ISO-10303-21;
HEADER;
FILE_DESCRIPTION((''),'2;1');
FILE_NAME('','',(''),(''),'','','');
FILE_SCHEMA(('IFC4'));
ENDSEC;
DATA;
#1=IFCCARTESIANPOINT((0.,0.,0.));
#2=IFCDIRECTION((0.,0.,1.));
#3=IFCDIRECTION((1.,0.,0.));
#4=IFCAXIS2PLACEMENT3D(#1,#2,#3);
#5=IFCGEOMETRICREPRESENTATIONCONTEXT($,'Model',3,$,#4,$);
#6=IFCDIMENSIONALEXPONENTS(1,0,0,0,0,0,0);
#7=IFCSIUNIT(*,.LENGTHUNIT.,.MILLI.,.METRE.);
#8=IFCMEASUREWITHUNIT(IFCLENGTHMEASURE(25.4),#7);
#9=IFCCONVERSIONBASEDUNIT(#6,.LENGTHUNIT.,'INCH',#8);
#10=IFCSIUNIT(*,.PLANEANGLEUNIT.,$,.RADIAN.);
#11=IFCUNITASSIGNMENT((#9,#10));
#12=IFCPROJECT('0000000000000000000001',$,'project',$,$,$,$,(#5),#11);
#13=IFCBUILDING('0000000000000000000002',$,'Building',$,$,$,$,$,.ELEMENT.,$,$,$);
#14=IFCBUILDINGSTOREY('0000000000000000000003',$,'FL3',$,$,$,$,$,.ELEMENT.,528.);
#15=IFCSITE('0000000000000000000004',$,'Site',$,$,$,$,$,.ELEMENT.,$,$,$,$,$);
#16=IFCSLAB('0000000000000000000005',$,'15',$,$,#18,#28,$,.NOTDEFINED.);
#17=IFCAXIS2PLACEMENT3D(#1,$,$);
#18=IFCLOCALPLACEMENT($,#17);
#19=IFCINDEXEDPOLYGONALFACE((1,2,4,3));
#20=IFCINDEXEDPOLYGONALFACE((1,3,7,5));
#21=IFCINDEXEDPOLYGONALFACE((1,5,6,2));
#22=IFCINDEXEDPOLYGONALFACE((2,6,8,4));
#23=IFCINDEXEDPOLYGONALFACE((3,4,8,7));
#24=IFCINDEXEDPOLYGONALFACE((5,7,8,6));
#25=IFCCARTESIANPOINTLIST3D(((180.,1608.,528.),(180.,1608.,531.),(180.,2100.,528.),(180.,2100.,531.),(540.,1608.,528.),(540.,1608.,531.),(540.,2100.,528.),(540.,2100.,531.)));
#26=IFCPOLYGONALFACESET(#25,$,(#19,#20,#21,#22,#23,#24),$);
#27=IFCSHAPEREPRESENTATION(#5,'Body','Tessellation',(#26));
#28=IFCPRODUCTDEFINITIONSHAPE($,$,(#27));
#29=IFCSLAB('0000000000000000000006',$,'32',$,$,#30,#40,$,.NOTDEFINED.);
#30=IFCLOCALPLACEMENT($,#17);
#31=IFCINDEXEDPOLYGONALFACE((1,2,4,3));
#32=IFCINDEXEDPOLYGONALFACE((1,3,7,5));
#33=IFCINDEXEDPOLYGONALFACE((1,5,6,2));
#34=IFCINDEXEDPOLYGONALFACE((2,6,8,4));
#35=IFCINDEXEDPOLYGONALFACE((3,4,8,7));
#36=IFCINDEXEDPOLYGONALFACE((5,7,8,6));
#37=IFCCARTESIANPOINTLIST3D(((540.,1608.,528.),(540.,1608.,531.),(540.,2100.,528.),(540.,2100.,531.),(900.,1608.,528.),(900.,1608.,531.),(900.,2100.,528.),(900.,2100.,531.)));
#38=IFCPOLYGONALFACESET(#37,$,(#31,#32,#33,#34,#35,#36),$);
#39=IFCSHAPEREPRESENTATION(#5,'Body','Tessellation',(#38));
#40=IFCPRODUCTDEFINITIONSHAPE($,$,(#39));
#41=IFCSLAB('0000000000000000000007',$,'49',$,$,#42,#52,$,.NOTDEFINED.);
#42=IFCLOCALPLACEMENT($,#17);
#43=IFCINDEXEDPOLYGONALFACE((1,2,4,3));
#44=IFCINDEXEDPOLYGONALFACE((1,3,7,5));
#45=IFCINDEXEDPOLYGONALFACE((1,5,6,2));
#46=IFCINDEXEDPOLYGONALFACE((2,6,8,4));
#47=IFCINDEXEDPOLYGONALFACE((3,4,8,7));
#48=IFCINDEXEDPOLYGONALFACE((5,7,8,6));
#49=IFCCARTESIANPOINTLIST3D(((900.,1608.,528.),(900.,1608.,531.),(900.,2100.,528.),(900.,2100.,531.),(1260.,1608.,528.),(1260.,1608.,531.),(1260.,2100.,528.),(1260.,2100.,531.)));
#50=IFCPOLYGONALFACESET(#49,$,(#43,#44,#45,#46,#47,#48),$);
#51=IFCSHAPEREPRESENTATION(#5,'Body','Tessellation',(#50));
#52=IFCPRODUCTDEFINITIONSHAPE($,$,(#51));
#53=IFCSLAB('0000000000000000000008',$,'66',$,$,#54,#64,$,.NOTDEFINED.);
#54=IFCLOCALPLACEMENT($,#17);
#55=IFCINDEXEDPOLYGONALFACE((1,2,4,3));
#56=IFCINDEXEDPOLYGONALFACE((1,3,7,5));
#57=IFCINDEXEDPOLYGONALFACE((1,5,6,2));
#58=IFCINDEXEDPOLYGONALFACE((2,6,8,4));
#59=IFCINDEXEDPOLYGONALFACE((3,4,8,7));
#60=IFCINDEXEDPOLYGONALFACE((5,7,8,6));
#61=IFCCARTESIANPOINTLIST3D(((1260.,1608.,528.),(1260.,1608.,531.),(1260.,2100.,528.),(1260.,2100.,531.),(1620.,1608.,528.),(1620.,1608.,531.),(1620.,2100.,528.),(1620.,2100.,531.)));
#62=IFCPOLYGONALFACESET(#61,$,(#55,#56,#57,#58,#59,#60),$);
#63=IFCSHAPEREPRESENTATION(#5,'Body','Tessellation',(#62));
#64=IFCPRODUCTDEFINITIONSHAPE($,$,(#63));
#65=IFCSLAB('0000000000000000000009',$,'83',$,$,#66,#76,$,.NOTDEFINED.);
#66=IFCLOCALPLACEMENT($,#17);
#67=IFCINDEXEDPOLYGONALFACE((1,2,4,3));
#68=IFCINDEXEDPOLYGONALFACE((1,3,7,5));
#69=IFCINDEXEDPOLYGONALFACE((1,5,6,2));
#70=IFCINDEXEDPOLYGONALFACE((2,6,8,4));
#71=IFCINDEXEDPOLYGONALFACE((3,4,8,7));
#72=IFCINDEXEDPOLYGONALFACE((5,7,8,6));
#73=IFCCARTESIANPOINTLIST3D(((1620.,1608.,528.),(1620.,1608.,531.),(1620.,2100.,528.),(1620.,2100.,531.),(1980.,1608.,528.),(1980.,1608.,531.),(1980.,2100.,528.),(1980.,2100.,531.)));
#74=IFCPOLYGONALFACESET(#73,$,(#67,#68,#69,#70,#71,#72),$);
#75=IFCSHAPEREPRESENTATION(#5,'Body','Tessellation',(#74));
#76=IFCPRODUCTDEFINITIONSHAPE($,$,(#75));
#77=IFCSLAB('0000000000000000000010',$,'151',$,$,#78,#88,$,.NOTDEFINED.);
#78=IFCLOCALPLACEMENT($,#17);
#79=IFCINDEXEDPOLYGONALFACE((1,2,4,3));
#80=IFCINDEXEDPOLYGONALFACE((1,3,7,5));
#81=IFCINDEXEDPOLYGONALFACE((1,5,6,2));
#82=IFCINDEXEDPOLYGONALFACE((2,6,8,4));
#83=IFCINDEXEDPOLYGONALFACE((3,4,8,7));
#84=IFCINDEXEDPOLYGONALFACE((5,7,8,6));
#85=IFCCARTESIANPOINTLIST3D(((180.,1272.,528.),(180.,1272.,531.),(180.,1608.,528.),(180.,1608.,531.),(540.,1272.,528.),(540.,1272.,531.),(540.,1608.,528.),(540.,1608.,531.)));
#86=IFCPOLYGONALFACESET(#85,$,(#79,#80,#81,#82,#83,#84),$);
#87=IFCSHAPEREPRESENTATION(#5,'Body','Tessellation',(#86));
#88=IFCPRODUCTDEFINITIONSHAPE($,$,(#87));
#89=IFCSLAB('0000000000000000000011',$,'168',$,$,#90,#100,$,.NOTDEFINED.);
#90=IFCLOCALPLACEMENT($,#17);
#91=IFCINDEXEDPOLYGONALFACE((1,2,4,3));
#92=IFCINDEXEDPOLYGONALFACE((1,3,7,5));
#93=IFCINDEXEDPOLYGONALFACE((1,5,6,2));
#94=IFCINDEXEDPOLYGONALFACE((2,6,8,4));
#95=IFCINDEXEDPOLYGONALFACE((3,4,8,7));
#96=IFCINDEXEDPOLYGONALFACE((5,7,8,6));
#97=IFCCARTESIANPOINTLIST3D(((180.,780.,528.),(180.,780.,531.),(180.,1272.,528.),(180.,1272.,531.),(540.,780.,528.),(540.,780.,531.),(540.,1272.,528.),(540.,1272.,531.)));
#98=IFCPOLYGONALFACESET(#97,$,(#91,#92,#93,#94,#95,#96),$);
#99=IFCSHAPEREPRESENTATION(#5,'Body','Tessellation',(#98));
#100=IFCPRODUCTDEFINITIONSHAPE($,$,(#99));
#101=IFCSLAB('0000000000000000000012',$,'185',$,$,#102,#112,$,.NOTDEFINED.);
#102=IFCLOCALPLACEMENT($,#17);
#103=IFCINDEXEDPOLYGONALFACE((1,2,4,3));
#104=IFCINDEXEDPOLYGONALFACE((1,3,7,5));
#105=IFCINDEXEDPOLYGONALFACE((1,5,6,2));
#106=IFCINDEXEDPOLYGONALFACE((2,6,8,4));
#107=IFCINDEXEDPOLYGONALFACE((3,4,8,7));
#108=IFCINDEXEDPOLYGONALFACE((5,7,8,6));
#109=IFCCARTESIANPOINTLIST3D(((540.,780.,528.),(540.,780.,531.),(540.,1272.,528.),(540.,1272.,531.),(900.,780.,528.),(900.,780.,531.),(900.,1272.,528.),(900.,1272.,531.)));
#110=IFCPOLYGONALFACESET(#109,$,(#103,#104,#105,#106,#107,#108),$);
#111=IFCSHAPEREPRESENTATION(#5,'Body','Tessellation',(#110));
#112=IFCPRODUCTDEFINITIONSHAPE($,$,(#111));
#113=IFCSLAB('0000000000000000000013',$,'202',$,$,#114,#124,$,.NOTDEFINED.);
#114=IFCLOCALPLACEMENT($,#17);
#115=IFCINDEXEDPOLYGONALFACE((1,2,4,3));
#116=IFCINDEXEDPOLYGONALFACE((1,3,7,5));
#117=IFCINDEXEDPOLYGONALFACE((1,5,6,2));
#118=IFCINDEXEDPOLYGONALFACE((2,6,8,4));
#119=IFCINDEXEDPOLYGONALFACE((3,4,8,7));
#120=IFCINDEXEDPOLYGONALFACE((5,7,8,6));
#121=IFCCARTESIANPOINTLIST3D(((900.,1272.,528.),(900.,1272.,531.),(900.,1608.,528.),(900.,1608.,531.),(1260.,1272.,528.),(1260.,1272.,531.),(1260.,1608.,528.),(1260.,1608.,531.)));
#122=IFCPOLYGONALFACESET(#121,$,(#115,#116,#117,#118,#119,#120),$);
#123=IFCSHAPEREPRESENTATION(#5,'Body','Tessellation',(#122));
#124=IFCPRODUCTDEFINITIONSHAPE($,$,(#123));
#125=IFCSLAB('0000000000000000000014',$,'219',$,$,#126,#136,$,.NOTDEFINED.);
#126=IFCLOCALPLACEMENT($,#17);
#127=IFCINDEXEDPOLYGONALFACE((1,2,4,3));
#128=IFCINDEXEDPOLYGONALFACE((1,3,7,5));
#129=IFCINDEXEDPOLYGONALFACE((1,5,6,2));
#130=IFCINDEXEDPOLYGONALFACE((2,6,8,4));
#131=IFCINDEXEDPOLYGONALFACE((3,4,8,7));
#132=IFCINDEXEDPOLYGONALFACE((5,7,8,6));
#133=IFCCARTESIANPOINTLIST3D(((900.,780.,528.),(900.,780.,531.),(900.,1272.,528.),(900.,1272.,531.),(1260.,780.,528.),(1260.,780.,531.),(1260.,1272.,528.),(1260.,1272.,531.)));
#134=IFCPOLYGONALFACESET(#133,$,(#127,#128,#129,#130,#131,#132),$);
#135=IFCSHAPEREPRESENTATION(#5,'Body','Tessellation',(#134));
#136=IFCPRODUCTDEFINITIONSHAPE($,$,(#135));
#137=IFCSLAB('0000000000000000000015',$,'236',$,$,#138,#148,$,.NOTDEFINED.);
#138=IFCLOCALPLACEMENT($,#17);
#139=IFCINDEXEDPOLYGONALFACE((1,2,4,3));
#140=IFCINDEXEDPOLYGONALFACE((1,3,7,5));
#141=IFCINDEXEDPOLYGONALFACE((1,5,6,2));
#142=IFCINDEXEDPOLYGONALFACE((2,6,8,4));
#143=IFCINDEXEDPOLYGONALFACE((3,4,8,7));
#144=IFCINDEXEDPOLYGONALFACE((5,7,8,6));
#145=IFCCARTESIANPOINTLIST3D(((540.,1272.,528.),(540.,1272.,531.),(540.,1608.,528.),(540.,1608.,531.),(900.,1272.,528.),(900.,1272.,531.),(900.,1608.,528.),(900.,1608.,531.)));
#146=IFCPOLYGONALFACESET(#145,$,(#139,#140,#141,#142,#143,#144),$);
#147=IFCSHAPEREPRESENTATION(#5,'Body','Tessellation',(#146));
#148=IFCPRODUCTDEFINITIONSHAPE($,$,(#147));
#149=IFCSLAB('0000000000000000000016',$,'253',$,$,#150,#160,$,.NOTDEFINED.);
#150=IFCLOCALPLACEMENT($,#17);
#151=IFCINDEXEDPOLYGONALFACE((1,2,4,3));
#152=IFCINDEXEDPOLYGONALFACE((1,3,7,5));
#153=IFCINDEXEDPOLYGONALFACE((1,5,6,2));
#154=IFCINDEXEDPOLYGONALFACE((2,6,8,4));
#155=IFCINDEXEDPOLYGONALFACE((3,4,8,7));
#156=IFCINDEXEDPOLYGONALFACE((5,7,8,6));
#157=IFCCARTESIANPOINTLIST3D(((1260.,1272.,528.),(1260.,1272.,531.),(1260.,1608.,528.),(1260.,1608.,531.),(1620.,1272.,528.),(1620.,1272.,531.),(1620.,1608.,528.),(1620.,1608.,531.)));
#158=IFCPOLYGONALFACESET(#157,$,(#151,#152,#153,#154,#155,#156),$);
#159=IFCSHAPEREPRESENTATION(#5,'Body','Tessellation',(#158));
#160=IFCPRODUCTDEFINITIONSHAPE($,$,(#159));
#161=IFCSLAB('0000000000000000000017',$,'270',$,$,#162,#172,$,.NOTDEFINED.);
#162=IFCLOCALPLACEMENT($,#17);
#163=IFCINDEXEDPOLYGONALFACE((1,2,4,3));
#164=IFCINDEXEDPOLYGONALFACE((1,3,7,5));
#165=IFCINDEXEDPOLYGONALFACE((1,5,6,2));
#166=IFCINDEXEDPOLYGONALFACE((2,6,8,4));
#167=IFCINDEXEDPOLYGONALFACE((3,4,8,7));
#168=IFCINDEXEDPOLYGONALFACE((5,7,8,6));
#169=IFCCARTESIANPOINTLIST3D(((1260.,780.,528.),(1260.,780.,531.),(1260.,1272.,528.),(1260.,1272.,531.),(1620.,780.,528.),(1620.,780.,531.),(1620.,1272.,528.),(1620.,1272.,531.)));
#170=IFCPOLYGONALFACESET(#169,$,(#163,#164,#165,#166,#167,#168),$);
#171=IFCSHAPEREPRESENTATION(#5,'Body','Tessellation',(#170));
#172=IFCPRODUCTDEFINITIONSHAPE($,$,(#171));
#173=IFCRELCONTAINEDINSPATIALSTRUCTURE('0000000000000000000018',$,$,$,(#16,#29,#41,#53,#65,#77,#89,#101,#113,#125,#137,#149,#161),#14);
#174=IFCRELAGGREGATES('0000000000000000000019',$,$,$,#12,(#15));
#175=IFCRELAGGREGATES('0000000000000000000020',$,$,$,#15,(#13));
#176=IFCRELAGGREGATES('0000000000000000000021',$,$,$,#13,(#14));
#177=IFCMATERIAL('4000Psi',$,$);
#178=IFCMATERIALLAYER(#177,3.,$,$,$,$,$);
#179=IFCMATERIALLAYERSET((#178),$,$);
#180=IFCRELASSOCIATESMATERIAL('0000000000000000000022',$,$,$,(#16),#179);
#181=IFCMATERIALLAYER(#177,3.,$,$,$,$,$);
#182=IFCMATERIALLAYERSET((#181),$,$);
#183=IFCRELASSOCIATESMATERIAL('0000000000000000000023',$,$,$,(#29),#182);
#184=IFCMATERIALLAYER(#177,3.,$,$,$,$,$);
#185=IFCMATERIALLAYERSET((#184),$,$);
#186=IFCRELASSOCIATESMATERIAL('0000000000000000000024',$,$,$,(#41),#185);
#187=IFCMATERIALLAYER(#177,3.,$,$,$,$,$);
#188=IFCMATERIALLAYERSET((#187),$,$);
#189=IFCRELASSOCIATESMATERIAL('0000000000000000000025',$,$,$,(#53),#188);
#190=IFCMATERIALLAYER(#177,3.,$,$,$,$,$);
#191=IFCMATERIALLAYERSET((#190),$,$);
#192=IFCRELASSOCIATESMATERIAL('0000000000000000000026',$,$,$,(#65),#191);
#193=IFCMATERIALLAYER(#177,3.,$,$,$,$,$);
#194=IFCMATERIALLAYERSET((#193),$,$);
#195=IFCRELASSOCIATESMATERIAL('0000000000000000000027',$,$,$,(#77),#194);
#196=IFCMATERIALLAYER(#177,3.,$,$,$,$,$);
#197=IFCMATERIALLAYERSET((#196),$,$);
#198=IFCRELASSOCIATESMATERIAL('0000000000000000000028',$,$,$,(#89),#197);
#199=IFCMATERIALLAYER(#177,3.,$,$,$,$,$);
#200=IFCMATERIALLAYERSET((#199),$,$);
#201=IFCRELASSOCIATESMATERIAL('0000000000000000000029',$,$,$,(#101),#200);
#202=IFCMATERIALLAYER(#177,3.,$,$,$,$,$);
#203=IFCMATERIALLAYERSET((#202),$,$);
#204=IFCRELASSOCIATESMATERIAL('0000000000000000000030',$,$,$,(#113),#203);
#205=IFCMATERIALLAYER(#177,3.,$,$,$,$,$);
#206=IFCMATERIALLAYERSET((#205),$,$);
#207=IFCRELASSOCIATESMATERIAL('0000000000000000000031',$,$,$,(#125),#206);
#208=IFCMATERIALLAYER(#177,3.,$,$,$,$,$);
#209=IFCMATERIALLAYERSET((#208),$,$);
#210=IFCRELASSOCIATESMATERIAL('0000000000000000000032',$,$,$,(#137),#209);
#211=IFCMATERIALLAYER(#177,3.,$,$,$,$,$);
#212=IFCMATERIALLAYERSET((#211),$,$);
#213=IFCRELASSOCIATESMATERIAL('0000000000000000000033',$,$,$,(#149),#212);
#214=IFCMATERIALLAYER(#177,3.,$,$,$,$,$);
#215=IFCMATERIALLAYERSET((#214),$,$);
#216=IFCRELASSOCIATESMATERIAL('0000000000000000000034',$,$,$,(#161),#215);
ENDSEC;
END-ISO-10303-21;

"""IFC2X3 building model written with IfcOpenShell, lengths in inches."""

from ifc_helpers import new_model, entity, si_unit, converted_unit, frame, origin_with_axes, place, context, project, spatial, polyline, outline, extrude, material, layer, layer_set, layer_usage, element, save


model = new_model("IFC2X3")

# Units and contexts
model_context = context("Model", 3, world=origin_with_axes())
ifc_project = project(units=[converted_unit("LENGTHUNIT", "INCH", entity("IfcLengthMeasure", 25.4), si_unit("LENGTHUNIT", "METRE", prefix="MILLI"), dimensions=[1, 0, 0, 0, 0, 0, 0]), si_unit("PLANEANGLEUNIT", "RADIAN")], contexts=[model_context])

# Site, building, storey
site = spatial("IfcSite", under=ifc_project, Name="Site", CompositionType="ELEMENT")
building = spatial("IfcBuilding", under=site, Name="Building", CompositionType="ELEMENT")
storey = spatial("IfcBuildingStorey", under=building, Name="FL3", CompositionType="ELEMENT", Elevation=528.0)

# Slabs
ifc_material_1 = material(Name="4000Psi")
ifc_layer_1 = layer(ifc_material_1, 3.0)
ifc_layer_set_1 = layer_set([ifc_layer_1])
ifc_layer_usage_1 = layer_usage(ifc_layer_set_1, "AXIS2", "POSITIVE", -3.0)
slab_1_placement = place(None, frame((180.0, 1608.0, 528.0), z_axis=(0.0, 0.0, 1.0), x_axis=(1.0, 0.0, 0.0)))
element("IfcSlab", 1, at=slab_1_placement, inside=storey, material=ifc_layer_usage_1, Name="15", PredefinedType="NOTDEFINED", context=model_context, shape_type="SweptSolid", body=[
    extrude(outline(polyline([(0.0, 0.0), (360.0, 0.0), (360.0, 492.0), (0.0, 492.0), (0.0, 0.0)])), origin_with_axes(), (0.0, 0.0, 1.0), 3.0),
])
ifc_layer_2 = layer(ifc_material_1, 3.0)
ifc_layer_set_2 = layer_set([ifc_layer_2])
ifc_layer_usage_2 = layer_usage(ifc_layer_set_2, "AXIS2", "POSITIVE", -3.0)
slab_2_placement = place(None, frame((540.0, 1608.0, 528.0), z_axis=(0.0, 0.0, 1.0), x_axis=(1.0, 0.0, 0.0)))
element("IfcSlab", 2, at=slab_2_placement, inside=storey, material=ifc_layer_usage_2, Name="32", PredefinedType="NOTDEFINED", context=model_context, shape_type="SweptSolid", body=[
    extrude(outline(polyline([(0.0, 0.0), (360.0, 0.0), (360.0, 492.0), (0.0, 492.0), (0.0, 0.0)])), origin_with_axes(), (0.0, 0.0, 1.0), 3.0),
])
ifc_layer_3 = layer(ifc_material_1, 3.0)
ifc_layer_set_3 = layer_set([ifc_layer_3])
ifc_layer_usage_3 = layer_usage(ifc_layer_set_3, "AXIS2", "POSITIVE", -3.0)
slab_3_placement = place(None, frame((900.0, 1608.0, 528.0), z_axis=(0.0, 0.0, 1.0), x_axis=(1.0, 0.0, 0.0)))
element("IfcSlab", 3, at=slab_3_placement, inside=storey, material=ifc_layer_usage_3, Name="49", PredefinedType="NOTDEFINED", context=model_context, shape_type="SweptSolid", body=[
    extrude(outline(polyline([(0.0, 0.0), (360.0, 0.0), (360.0, 492.0), (0.0, 492.0), (0.0, 0.0)])), origin_with_axes(), (0.0, 0.0, 1.0), 3.0),
])
ifc_layer_4 = layer(ifc_material_1, 3.0)
ifc_layer_set_4 = layer_set([ifc_layer_4])
ifc_layer_usage_4 = layer_usage(ifc_layer_set_4, "AXIS2", "POSITIVE", -3.0)
slab_4_placement = place(None, frame((1260.0, 1608.0, 528.0), z_axis=(0.0, 0.0, 1.0), x_axis=(1.0, 0.0, 0.0)))
element("IfcSlab", 4, at=slab_4_placement, inside=storey, material=ifc_layer_usage_4, Name="66", PredefinedType="NOTDEFINED", context=model_context, shape_type="SweptSolid", body=[
    extrude(outline(polyline([(0.0, 0.0), (360.0, 0.0), (360.0, 492.0), (0.0, 492.0), (0.0, 0.0)])), origin_with_axes(), (0.0, 0.0, 1.0), 3.0),
])
ifc_layer_5 = layer(ifc_material_1, 3.0)
ifc_layer_set_5 = layer_set([ifc_layer_5])
ifc_layer_usage_5 = layer_usage(ifc_layer_set_5, "AXIS2", "POSITIVE", -3.0)
slab_5_placement = place(None, frame((1620.0, 1608.0, 528.0), z_axis=(0.0, 0.0, 1.0), x_axis=(1.0, 0.0, 0.0)))
element("IfcSlab", 5, at=slab_5_placement, inside=storey, material=ifc_layer_usage_5, Name="83", PredefinedType="NOTDEFINED", context=model_context, shape_type="SweptSolid", body=[
    extrude(outline(polyline([(0.0, 0.0), (360.0, 0.0), (360.0, 492.0), (0.0, 492.0), (0.0, 0.0)])), origin_with_axes(), (0.0, 0.0, 1.0), 3.0),
])
ifc_layer_6 = layer(ifc_material_1, 3.0)
ifc_layer_set_6 = layer_set([ifc_layer_6])
ifc_layer_usage_6 = layer_usage(ifc_layer_set_6, "AXIS2", "POSITIVE", -3.0)
slab_6_placement = place(None, frame((180.0, 1272.0, 528.0), z_axis=(0.0, 0.0, 1.0), x_axis=(1.0, 0.0, 0.0)))
element("IfcSlab", 6, at=slab_6_placement, inside=storey, material=ifc_layer_usage_6, Name="151", PredefinedType="NOTDEFINED", context=model_context, shape_type="SweptSolid", body=[
    extrude(outline(polyline([(0.0, 0.0), (360.0, 0.0), (360.0, 336.0), (0.0, 336.0), (0.0, 0.0)])), origin_with_axes(), (0.0, 0.0, 1.0), 3.0),
])
ifc_layer_7 = layer(ifc_material_1, 3.0)
ifc_layer_set_7 = layer_set([ifc_layer_7])
ifc_layer_usage_7 = layer_usage(ifc_layer_set_7, "AXIS2", "POSITIVE", -3.0)
slab_7_placement = place(None, frame((180.0, 780.0, 528.0), z_axis=(0.0, 0.0, 1.0), x_axis=(1.0, 0.0, 0.0)))
element("IfcSlab", 7, at=slab_7_placement, inside=storey, material=ifc_layer_usage_7, Name="168", PredefinedType="NOTDEFINED", context=model_context, shape_type="SweptSolid", body=[
    extrude(outline(polyline([(0.0, 0.0), (360.0, 0.0), (360.0, 492.0), (0.0, 492.0), (0.0, 0.0)])), origin_with_axes(), (0.0, 0.0, 1.0), 3.0),
])
ifc_layer_8 = layer(ifc_material_1, 3.0)
ifc_layer_set_8 = layer_set([ifc_layer_8])
ifc_layer_usage_8 = layer_usage(ifc_layer_set_8, "AXIS2", "POSITIVE", -3.0)
slab_8_placement = place(None, frame((540.0, 780.0, 528.0), z_axis=(0.0, 0.0, 1.0), x_axis=(1.0, 0.0, 0.0)))
element("IfcSlab", 8, at=slab_8_placement, inside=storey, material=ifc_layer_usage_8, Name="185", PredefinedType="NOTDEFINED", context=model_context, shape_type="SweptSolid", body=[
    extrude(outline(polyline([(0.0, 0.0), (360.0, 0.0), (360.0, 492.0), (0.0, 492.0), (0.0, 0.0)])), origin_with_axes(), (0.0, 0.0, 1.0), 3.0),
])
ifc_layer_9 = layer(ifc_material_1, 3.0)
ifc_layer_set_9 = layer_set([ifc_layer_9])
ifc_layer_usage_9 = layer_usage(ifc_layer_set_9, "AXIS2", "POSITIVE", -3.0)
slab_9_placement = place(None, frame((900.0, 1272.0, 528.0), z_axis=(0.0, 0.0, 1.0), x_axis=(1.0, 0.0, 0.0)))
element("IfcSlab", 9, at=slab_9_placement, inside=storey, material=ifc_layer_usage_9, Name="202", PredefinedType="NOTDEFINED", context=model_context, shape_type="SweptSolid", body=[
    extrude(outline(polyline([(0.0, 0.0), (360.0, 0.0), (360.0, 336.0), (0.0, 336.0), (0.0, 0.0)])), origin_with_axes(), (0.0, 0.0, 1.0), 3.0),
])
ifc_layer_10 = layer(ifc_material_1, 3.0)
ifc_layer_set_10 = layer_set([ifc_layer_10])
ifc_layer_usage_10 = layer_usage(ifc_layer_set_10, "AXIS2", "POSITIVE", -3.0)
slab_10_placement = place(None, frame((900.0, 780.0, 528.0), z_axis=(0.0, 0.0, 1.0), x_axis=(1.0, 0.0, 0.0)))
element("IfcSlab", 10, at=slab_10_placement, inside=storey, material=ifc_layer_usage_10, Name="219", PredefinedType="NOTDEFINED", context=model_context, shape_type="SweptSolid", body=[
    extrude(outline(polyline([(0.0, 0.0), (360.0, 0.0), (360.0, 492.0), (0.0, 492.0), (0.0, 0.0)])), origin_with_axes(), (0.0, 0.0, 1.0), 3.0),
])
ifc_layer_11 = layer(ifc_material_1, 3.0)
ifc_layer_set_11 = layer_set([ifc_layer_11])
ifc_layer_usage_11 = layer_usage(ifc_layer_set_11, "AXIS2", "POSITIVE", -3.0)
slab_11_placement = place(None, frame((540.0, 1272.0, 528.0), z_axis=(0.0, 0.0, 1.0), x_axis=(1.0, 0.0, 0.0)))
element("IfcSlab", 11, at=slab_11_placement, inside=storey, material=ifc_layer_usage_11, Name="236", PredefinedType="NOTDEFINED", context=model_context, shape_type="SweptSolid", body=[
    extrude(outline(polyline([(0.0, 0.0), (360.0, 0.0), (360.0, 336.0), (0.0, 336.0), (0.0, 0.0)])), origin_with_axes(), (0.0, 0.0, 1.0), 3.0),
])
ifc_layer_12 = layer(ifc_material_1, 3.0)
ifc_layer_set_12 = layer_set([ifc_layer_12])
ifc_layer_usage_12 = layer_usage(ifc_layer_set_12, "AXIS2", "POSITIVE", -3.0)
slab_12_placement = place(None, frame((1260.0, 1272.0, 528.0), z_axis=(0.0, 0.0, 1.0), x_axis=(1.0, 0.0, 0.0)))
element("IfcSlab", 12, at=slab_12_placement, inside=storey, material=ifc_layer_usage_12, Name="253", PredefinedType="NOTDEFINED", context=model_context, shape_type="SweptSolid", body=[
    extrude(outline(polyline([(0.0, 0.0), (360.0, 0.0), (360.0, 336.0), (0.0, 336.0), (0.0, 0.0)])), origin_with_axes(), (0.0, 0.0, 1.0), 3.0),
])
ifc_layer_13 = layer(ifc_material_1, 3.0)
ifc_layer_set_13 = layer_set([ifc_layer_13])
ifc_layer_usage_13 = layer_usage(ifc_layer_set_13, "AXIS2", "POSITIVE", -3.0)
slab_13_placement = place(None, frame((1260.0, 780.0, 528.0), z_axis=(0.0, 0.0, 1.0), x_axis=(1.0, 0.0, 0.0)))
element("IfcSlab", 13, at=slab_13_placement, inside=storey, material=ifc_layer_usage_13, Name="270", PredefinedType="NOTDEFINED", context=model_context, shape_type="SweptSolid", body=[
    extrude(outline(polyline([(0.0, 0.0), (360.0, 0.0), (360.0, 492.0), (0.0, 492.0), (0.0, 0.0)])), origin_with_axes(), (0.0, 0.0, 1.0), 3.0),
])

save(model, "model.ifc")
